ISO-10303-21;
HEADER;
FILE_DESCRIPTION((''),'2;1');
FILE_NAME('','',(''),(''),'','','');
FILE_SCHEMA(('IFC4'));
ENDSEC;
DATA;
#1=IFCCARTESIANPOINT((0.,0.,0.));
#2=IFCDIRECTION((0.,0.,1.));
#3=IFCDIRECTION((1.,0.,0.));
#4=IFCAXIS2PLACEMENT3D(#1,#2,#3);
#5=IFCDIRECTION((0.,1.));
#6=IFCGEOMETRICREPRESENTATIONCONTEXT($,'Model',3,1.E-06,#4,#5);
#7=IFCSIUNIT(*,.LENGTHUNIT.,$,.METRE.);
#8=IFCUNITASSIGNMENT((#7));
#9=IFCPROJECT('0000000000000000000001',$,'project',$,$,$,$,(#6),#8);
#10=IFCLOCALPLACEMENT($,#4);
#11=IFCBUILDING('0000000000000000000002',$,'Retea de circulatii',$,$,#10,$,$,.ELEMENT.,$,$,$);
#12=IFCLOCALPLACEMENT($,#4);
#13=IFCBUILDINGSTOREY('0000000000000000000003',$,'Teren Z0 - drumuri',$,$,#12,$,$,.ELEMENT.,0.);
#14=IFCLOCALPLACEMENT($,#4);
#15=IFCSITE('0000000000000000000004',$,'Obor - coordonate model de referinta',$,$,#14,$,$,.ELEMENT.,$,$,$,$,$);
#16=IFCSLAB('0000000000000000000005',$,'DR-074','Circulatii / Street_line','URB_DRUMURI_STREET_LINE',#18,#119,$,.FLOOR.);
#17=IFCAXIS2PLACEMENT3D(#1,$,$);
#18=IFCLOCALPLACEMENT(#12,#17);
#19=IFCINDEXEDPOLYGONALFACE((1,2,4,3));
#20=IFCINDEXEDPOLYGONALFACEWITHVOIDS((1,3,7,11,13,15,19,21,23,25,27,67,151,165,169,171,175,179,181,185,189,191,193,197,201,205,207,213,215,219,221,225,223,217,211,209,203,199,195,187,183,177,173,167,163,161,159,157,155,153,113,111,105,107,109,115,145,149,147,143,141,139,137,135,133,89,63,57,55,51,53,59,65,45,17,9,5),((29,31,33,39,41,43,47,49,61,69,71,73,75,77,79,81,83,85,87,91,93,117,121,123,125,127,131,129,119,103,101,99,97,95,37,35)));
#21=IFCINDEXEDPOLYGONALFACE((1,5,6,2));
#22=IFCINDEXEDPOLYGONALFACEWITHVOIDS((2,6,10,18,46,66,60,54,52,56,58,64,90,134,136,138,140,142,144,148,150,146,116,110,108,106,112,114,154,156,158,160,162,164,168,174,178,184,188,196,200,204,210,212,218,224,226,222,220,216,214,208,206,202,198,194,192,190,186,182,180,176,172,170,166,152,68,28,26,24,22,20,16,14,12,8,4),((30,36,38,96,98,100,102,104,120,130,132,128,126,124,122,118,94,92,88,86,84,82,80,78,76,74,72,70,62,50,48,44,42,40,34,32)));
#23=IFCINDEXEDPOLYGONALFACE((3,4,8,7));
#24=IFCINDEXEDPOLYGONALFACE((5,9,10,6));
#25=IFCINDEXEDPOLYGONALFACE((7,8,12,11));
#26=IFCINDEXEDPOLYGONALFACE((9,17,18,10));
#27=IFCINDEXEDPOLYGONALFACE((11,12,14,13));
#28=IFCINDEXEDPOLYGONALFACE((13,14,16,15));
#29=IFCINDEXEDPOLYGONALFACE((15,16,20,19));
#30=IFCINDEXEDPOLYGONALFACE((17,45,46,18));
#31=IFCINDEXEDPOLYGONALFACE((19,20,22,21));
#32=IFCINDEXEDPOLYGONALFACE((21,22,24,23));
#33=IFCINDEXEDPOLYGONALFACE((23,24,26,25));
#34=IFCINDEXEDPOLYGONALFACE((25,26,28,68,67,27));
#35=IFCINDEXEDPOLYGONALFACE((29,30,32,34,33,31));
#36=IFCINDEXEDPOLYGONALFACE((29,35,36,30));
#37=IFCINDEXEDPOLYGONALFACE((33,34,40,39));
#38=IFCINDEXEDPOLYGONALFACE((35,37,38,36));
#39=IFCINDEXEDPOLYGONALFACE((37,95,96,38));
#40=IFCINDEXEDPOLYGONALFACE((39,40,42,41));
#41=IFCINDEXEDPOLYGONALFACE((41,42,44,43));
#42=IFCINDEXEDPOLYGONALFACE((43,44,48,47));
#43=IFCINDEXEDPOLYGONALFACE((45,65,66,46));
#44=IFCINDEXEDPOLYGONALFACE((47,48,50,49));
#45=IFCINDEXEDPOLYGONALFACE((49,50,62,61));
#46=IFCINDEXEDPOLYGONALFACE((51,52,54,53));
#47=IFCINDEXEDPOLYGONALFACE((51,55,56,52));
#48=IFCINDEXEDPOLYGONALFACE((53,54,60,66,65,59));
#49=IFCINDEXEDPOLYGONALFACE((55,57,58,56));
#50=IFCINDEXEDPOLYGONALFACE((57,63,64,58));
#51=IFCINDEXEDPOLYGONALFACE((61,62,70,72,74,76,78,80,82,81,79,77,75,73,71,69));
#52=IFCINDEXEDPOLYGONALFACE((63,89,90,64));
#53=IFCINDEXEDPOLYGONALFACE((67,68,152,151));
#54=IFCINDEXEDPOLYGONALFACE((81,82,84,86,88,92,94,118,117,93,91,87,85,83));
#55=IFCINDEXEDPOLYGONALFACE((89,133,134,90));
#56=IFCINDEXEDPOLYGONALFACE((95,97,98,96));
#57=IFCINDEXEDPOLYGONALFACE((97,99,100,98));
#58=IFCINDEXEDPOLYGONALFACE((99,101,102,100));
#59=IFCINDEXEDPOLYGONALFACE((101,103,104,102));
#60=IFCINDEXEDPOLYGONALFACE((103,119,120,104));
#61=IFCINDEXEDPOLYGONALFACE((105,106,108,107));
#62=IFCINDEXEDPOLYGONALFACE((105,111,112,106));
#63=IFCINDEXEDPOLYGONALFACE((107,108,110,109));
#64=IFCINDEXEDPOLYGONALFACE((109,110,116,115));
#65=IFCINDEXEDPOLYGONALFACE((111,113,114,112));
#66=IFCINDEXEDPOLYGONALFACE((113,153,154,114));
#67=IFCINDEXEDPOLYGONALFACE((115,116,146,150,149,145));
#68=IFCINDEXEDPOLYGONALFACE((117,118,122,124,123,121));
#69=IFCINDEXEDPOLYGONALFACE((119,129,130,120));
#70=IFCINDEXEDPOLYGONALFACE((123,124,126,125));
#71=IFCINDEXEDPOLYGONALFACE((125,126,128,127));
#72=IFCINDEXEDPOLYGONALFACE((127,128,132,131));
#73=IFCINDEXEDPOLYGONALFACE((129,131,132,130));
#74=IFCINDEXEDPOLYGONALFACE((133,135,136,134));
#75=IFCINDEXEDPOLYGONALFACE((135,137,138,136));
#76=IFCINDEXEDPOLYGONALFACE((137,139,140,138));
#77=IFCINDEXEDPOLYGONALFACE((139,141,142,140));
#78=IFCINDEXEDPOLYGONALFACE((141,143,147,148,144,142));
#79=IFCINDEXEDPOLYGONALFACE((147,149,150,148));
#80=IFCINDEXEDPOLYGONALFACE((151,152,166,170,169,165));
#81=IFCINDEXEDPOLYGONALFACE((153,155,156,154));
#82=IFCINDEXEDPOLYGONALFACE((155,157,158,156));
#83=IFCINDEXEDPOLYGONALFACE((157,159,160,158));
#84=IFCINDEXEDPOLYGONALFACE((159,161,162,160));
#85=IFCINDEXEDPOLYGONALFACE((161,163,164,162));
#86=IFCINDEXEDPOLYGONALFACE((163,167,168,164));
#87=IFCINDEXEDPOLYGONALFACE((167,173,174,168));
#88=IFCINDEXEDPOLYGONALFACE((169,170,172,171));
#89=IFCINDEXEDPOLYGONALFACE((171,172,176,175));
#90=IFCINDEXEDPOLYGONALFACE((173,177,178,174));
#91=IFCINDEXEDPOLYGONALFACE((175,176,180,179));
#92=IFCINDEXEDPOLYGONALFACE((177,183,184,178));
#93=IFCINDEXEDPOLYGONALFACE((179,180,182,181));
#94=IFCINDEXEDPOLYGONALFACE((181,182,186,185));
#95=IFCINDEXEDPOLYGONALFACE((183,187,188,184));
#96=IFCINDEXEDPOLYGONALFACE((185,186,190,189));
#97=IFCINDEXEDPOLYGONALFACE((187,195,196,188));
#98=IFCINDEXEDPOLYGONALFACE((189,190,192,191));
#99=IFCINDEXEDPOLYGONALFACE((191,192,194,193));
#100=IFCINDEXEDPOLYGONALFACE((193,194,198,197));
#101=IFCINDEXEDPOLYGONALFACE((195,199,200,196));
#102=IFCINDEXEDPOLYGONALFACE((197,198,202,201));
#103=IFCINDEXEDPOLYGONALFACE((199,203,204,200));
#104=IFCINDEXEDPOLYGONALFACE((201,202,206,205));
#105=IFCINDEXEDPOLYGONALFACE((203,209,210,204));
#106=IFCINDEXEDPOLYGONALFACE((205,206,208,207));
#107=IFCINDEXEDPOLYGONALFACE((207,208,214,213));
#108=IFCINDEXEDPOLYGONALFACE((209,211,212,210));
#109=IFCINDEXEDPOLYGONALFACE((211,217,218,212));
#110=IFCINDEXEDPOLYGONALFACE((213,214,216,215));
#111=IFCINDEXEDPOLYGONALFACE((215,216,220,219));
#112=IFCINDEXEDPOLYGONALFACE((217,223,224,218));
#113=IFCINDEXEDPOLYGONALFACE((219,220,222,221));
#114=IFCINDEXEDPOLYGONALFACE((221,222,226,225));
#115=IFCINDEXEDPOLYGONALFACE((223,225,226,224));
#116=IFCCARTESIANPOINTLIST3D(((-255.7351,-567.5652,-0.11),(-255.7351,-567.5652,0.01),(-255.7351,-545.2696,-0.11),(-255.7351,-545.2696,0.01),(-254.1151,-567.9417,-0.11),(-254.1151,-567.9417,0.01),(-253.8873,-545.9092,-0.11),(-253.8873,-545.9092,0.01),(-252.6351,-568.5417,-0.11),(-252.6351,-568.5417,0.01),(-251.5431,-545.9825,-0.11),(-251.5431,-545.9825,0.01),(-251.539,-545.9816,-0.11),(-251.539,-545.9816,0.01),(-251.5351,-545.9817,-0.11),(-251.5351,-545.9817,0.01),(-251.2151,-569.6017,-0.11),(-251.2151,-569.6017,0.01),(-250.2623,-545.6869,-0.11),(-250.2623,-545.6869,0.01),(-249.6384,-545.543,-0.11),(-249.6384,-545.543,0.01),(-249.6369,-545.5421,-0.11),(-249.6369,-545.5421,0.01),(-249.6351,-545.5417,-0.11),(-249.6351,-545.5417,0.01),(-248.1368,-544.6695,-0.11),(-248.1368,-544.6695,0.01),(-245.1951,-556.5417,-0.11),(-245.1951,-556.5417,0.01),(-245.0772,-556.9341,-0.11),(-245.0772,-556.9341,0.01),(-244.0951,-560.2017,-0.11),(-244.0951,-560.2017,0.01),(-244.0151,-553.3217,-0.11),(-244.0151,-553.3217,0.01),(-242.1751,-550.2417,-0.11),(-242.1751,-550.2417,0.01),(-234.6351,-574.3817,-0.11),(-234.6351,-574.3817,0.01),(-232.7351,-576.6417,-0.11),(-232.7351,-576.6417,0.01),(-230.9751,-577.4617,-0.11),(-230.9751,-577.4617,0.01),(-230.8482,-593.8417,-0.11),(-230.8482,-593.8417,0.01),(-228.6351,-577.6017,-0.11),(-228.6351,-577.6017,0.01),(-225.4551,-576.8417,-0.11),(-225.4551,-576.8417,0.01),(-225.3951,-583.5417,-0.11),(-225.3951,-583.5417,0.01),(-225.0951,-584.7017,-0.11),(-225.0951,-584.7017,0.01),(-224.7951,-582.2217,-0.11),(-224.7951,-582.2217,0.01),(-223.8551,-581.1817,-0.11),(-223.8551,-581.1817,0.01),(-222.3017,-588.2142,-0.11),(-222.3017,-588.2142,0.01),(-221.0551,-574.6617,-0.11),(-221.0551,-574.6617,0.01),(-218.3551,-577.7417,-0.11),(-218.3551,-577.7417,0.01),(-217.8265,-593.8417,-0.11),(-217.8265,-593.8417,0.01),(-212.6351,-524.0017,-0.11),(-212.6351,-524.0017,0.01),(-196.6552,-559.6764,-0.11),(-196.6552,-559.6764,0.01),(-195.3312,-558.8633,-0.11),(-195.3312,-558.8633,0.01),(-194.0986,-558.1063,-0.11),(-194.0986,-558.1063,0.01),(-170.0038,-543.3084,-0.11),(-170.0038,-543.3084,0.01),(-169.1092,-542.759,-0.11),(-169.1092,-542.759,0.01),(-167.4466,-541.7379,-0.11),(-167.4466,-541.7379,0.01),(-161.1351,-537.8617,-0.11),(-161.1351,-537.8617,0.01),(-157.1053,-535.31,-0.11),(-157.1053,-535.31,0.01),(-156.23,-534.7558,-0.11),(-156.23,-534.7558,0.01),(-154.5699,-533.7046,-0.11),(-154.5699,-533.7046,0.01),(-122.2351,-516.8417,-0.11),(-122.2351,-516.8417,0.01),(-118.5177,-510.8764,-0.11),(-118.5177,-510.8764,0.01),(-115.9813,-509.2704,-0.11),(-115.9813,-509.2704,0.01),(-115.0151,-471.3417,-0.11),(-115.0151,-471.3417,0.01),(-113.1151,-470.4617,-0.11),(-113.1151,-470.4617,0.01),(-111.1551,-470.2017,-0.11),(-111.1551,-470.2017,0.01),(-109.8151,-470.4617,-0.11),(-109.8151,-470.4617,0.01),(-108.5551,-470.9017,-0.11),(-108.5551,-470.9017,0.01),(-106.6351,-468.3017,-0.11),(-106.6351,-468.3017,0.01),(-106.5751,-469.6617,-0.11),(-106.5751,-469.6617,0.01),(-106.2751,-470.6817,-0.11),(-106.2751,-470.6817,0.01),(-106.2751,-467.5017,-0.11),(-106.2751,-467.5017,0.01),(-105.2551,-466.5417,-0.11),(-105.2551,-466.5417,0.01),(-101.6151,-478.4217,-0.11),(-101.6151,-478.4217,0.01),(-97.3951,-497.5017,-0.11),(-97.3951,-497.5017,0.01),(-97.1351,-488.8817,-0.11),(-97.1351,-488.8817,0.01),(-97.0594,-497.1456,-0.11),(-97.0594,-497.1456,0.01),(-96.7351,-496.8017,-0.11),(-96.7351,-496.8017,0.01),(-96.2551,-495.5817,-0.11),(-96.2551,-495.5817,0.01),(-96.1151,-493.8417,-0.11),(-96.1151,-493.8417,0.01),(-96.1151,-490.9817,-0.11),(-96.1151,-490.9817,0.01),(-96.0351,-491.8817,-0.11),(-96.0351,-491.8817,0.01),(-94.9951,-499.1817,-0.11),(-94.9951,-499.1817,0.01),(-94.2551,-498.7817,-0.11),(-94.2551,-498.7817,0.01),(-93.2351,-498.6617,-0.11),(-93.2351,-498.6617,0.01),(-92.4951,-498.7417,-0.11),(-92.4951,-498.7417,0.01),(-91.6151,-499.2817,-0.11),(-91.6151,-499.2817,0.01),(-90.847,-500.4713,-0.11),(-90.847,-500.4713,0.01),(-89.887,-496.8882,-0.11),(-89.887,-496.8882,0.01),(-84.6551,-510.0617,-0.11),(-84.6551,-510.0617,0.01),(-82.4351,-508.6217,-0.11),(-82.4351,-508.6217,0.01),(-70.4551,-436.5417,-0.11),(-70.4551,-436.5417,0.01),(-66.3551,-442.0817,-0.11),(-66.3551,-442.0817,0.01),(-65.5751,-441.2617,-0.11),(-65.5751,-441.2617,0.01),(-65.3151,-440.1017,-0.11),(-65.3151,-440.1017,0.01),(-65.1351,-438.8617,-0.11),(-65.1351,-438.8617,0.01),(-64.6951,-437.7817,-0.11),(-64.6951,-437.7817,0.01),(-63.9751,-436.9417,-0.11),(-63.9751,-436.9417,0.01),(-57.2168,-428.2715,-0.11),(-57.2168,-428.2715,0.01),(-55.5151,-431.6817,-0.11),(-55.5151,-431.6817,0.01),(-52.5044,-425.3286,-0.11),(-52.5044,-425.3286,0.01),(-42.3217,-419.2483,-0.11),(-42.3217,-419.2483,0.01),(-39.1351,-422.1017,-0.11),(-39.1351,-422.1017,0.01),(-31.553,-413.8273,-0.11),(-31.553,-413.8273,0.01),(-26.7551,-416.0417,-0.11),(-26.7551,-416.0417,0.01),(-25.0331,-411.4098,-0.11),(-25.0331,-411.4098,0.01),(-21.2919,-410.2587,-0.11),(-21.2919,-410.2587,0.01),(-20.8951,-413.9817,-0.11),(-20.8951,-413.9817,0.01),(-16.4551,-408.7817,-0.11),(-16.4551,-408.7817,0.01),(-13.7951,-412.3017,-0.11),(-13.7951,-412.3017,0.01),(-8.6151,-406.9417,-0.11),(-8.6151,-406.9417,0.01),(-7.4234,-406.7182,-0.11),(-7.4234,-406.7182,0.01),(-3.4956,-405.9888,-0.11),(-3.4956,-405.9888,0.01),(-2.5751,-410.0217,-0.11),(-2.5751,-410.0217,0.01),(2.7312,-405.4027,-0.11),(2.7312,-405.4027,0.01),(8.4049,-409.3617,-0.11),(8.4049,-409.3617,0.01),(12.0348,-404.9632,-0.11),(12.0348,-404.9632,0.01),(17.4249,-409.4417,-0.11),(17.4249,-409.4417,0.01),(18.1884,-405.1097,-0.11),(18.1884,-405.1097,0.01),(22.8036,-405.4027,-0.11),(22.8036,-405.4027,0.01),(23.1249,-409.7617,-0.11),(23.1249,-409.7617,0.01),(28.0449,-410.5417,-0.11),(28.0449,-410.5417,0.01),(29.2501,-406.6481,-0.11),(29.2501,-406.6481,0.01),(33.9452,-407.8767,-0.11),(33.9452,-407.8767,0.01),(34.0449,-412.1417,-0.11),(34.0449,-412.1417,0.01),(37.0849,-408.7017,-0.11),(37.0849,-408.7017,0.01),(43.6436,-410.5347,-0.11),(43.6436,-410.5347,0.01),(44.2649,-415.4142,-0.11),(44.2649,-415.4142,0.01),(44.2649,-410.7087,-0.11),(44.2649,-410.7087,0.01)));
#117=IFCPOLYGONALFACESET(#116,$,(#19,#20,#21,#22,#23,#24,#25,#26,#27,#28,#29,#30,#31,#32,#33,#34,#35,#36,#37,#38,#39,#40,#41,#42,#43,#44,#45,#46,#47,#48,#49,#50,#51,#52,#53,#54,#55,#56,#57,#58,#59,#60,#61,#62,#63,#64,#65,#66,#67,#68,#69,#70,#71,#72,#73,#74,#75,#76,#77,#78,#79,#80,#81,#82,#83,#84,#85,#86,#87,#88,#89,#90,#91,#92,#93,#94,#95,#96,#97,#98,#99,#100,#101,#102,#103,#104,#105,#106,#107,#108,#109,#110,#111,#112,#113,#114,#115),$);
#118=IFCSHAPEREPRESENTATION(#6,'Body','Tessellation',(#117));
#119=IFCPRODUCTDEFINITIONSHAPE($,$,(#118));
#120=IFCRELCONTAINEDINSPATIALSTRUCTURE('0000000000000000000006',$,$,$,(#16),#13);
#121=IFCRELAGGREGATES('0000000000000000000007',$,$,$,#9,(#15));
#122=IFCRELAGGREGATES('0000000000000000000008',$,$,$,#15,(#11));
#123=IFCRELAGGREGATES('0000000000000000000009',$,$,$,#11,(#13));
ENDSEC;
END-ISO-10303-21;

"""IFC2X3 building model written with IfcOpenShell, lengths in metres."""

from ifc_helpers import new_model, si_unit, direction, frame, origin_with_axes, place, context, project, spatial, polyline, outline, extrude, element, save


model = new_model("IFC2X3")

# Units and contexts
model_context = context("Model", 3, precision=1e-06, world=origin_with_axes(), true_north=direction((0.0, 1.0)))
ifc_project = project(units=[si_unit("LENGTHUNIT", "METRE")], contexts=[model_context])

# Site, building, storey
site_placement = place(None, origin_with_axes())
site = spatial("IfcSite", under=ifc_project, at=site_placement, Name="Obor - coordonate model de referinta", CompositionType="ELEMENT")
building_placement = place(None, origin_with_axes())
building = spatial("IfcBuilding", under=site, at=building_placement, Name="Retea de circulatii", CompositionType="ELEMENT")
storey_placement = place(None, origin_with_axes())
storey = spatial("IfcBuildingStorey", under=building, at=storey_placement, Name="Teren Z0 - drumuri", CompositionType="ELEMENT", Elevation=0.0)

# Slab
slab_1_placement = place(None, origin_with_axes())
element("IfcSlab", 1, at=slab_1_placement, inside=storey, Name="DR-074", Description="Circulatii / Street_line", ObjectType="URB_DRUMURI_STREET_LINE", PredefinedType="FLOOR", context=model_context, shape_type="SweptSolid", body=[
    extrude(outline(polyline([(-254.1151, -567.9417), (-252.6351, -568.5417), (-251.2151, -569.6017), (-230.8482, -593.8417), (-217.8265, -593.8417), (-222.3017, -588.2142), (-225.0951, -584.7017), (-225.3951, -583.5417), (-224.7951, -582.2217), (-223.8551, -581.1817), (-218.3551, -577.7417), (-122.2351, -516.8417), (-94.9951, -499.1817), (-94.2551, -498.7817), (-93.2351, -498.6617), (-92.4951, -498.7417), (-91.6151, -499.2817), (-90.847, -500.4713), (-84.6551, -510.0617), (-82.4351, -508.6217), (-89.887, -496.8882), (-101.6151, -478.4217), (-106.2751, -470.6817), (-106.5751, -469.6617), (-106.6351, -468.3017), (-106.2751, -467.5017), (-105.2551, -466.5417), (-66.3551, -442.0817), (-65.5751, -441.2617), (-65.3151, -440.1017), (-65.1351, -438.8617), (-64.6951, -437.7817), (-63.9751, -436.9417), (-55.5151, -431.6817), (-39.1351, -422.1017), (-26.7551, -416.0417), (-20.8951, -413.9817), (-13.7951, -412.3017), (-2.5751, -410.0217), (8.4049, -409.3617), (17.4249, -409.4417), (23.1249, -409.7617), (28.0449, -410.5417), (34.0449, -412.1417), (44.2649, -415.4142), (44.2649, -410.7087), (43.6436, -410.5347), (37.0849, -408.7017), (33.9452, -407.8767), (29.2501, -406.6481), (22.8036, -405.4027), (18.1884, -405.1097), (12.0348, -404.9632), (2.7312, -405.4027), (-3.4956, -405.9888), (-7.4234, -406.7182), (-8.6151, -406.9417), (-16.4551, -408.7817), (-21.2919, -410.2587), (-25.0331, -411.4098), (-31.553, -413.8273), (-42.3217, -419.2483), (-52.5044, -425.3286), (-57.2168, -428.2715), (-70.4551, -436.5417), (-212.6351, -524.0017), (-248.1368, -544.6695), (-249.6351, -545.5417), (-249.6369, -545.5421), (-249.6384, -545.543), (-250.2623, -545.6869), (-251.5351, -545.9817), (-251.539, -545.9816), (-251.5431, -545.9825), (-253.8873, -545.9092), (-255.7351, -545.2696), (-255.7351, -567.5652), (-254.1151, -567.9417)]), holes=[polyline([(-221.0551, -574.6617), (-225.4551, -576.8417), (-228.6351, -577.6017), (-230.9751, -577.4617), (-232.7351, -576.6417), (-234.6351, -574.3817), (-244.0951, -560.2017), (-245.0772, -556.9341), (-245.1951, -556.5417), (-244.0151, -553.3217), (-242.1751, -550.2417), (-115.0151, -471.3417), (-113.1151, -470.4617), (-111.1551, -470.2017), (-109.8151, -470.4617), (-108.5551, -470.9017), (-97.1351, -488.8817), (-96.1151, -490.9817), (-96.0351, -491.8817), (-96.1151, -493.8417), (-96.2551, -495.5817), (-96.7351, -496.8017), (-97.0594, -497.1456), (-97.3951, -497.5017), (-115.9813, -509.2704), (-118.5177, -510.8764), (-154.5699, -533.7046), (-156.23, -534.7558), (-157.1053, -535.31), (-161.1351, -537.8617), (-167.4466, -541.7379), (-169.1092, -542.759), (-170.0038, -543.3084), (-194.0986, -558.1063), (-195.3312, -558.8633), (-196.6552, -559.6764), (-221.0551, -574.6617)])]), frame((0.0, 0.0, -0.11), z_axis=(0.0, 0.0, 1.0), x_axis=(1.0, 0.0, 0.0)), (0.0, 0.0, 1.0), 0.12),
])

save(model, "model.ifc")
